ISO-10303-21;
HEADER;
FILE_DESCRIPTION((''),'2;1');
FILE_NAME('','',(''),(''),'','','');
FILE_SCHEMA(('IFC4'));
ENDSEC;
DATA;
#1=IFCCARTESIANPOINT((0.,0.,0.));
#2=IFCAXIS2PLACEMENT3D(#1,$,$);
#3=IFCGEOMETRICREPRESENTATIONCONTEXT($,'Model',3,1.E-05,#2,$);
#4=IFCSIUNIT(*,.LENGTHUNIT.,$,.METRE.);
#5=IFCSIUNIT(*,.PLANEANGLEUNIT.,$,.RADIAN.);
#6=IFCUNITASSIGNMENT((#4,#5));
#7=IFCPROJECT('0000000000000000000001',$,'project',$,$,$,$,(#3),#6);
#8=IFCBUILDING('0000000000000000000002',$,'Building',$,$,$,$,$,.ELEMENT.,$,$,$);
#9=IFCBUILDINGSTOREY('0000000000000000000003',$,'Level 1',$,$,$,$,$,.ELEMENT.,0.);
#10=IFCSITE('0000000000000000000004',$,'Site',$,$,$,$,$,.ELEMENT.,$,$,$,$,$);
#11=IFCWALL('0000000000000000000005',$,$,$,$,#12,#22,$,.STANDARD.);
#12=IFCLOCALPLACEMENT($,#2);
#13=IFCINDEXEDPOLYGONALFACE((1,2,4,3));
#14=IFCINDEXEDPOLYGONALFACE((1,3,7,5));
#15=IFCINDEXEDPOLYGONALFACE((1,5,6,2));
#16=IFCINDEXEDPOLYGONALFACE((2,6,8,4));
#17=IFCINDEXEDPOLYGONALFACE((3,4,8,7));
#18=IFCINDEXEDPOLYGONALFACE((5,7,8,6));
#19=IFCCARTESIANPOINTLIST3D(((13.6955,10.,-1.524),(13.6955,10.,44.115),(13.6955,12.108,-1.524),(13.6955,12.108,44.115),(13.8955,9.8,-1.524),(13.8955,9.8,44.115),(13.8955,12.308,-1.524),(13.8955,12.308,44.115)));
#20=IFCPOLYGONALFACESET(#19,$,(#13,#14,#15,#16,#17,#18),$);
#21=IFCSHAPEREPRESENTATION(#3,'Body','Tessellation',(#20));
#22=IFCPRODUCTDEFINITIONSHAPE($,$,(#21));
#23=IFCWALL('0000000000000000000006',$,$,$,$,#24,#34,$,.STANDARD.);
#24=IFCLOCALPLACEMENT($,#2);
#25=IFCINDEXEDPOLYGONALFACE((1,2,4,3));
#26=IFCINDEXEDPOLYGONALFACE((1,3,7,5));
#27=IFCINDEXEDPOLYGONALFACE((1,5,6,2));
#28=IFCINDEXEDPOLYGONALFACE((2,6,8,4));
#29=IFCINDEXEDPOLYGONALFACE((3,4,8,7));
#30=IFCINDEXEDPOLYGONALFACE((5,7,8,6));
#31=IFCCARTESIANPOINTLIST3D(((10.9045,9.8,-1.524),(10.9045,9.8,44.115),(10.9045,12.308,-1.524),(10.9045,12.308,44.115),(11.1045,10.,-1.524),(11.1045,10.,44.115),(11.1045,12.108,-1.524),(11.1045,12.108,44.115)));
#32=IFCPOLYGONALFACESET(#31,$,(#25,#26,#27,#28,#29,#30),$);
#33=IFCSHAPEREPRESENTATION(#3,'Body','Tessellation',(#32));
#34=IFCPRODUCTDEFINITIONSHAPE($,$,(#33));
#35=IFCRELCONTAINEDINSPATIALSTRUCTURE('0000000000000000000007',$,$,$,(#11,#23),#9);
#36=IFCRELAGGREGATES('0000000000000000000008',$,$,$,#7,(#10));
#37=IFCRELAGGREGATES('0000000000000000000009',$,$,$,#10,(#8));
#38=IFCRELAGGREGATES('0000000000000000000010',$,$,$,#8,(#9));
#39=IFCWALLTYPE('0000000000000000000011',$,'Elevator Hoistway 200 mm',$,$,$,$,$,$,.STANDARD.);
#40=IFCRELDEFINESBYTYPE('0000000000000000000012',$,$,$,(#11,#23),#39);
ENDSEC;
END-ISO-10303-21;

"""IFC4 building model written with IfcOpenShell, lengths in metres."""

from ifc_helpers import new_model, si_unit, frame, origin, place, context, project, spatial, polyline, outline, extrude, type_object, element, save


model = new_model("IFC4")

# Units and contexts
model_context = context("Model", 3, precision=1e-05, world=origin())
ifc_project = project(units=[si_unit("LENGTHUNIT", "METRE"), si_unit("PLANEANGLEUNIT", "RADIAN")], contexts=[model_context])

# Site, building, storey
site = spatial("IfcSite", under=ifc_project, Name="Site", CompositionType="ELEMENT")
building = spatial("IfcBuilding", under=site, Name="Building", CompositionType="ELEMENT")
storey = spatial("IfcBuildingStorey", under=building, Name="Level 1", CompositionType="ELEMENT", Elevation=0.0)

# Shared definitions
wall_type = type_object("IfcWallType", Name="Elevator Hoistway 200 mm", PredefinedType="STANDARD")

# Walls
for number, where, z_axis, x_axis in (
    (1, (13.7955, 9.9, -1.524), (0.0, 0.0, 1.0), (0.0, 1.0, 0.0)),
    (2, (11.0045, 12.208, -1.524), (0.0, 0.0, 1.0), (0.0, -1.0, 0.0)),
):
    element("IfcWall", number, at=place(None, frame(where, z_axis=z_axis, x_axis=x_axis)), inside=storey, type_object=wall_type, PredefinedType="STANDARD", context=model_context, shape_type="SweptSolid", body=[
        extrude(outline(polyline([(-0.1, -0.1), (2.408, -0.1), (2.208, 0.1), (0.1, 0.1), (-0.1, -0.1)])), origin(), (0.0, 0.0, 1.0), 45.639),
    ])

save(model, "model.ifc")
